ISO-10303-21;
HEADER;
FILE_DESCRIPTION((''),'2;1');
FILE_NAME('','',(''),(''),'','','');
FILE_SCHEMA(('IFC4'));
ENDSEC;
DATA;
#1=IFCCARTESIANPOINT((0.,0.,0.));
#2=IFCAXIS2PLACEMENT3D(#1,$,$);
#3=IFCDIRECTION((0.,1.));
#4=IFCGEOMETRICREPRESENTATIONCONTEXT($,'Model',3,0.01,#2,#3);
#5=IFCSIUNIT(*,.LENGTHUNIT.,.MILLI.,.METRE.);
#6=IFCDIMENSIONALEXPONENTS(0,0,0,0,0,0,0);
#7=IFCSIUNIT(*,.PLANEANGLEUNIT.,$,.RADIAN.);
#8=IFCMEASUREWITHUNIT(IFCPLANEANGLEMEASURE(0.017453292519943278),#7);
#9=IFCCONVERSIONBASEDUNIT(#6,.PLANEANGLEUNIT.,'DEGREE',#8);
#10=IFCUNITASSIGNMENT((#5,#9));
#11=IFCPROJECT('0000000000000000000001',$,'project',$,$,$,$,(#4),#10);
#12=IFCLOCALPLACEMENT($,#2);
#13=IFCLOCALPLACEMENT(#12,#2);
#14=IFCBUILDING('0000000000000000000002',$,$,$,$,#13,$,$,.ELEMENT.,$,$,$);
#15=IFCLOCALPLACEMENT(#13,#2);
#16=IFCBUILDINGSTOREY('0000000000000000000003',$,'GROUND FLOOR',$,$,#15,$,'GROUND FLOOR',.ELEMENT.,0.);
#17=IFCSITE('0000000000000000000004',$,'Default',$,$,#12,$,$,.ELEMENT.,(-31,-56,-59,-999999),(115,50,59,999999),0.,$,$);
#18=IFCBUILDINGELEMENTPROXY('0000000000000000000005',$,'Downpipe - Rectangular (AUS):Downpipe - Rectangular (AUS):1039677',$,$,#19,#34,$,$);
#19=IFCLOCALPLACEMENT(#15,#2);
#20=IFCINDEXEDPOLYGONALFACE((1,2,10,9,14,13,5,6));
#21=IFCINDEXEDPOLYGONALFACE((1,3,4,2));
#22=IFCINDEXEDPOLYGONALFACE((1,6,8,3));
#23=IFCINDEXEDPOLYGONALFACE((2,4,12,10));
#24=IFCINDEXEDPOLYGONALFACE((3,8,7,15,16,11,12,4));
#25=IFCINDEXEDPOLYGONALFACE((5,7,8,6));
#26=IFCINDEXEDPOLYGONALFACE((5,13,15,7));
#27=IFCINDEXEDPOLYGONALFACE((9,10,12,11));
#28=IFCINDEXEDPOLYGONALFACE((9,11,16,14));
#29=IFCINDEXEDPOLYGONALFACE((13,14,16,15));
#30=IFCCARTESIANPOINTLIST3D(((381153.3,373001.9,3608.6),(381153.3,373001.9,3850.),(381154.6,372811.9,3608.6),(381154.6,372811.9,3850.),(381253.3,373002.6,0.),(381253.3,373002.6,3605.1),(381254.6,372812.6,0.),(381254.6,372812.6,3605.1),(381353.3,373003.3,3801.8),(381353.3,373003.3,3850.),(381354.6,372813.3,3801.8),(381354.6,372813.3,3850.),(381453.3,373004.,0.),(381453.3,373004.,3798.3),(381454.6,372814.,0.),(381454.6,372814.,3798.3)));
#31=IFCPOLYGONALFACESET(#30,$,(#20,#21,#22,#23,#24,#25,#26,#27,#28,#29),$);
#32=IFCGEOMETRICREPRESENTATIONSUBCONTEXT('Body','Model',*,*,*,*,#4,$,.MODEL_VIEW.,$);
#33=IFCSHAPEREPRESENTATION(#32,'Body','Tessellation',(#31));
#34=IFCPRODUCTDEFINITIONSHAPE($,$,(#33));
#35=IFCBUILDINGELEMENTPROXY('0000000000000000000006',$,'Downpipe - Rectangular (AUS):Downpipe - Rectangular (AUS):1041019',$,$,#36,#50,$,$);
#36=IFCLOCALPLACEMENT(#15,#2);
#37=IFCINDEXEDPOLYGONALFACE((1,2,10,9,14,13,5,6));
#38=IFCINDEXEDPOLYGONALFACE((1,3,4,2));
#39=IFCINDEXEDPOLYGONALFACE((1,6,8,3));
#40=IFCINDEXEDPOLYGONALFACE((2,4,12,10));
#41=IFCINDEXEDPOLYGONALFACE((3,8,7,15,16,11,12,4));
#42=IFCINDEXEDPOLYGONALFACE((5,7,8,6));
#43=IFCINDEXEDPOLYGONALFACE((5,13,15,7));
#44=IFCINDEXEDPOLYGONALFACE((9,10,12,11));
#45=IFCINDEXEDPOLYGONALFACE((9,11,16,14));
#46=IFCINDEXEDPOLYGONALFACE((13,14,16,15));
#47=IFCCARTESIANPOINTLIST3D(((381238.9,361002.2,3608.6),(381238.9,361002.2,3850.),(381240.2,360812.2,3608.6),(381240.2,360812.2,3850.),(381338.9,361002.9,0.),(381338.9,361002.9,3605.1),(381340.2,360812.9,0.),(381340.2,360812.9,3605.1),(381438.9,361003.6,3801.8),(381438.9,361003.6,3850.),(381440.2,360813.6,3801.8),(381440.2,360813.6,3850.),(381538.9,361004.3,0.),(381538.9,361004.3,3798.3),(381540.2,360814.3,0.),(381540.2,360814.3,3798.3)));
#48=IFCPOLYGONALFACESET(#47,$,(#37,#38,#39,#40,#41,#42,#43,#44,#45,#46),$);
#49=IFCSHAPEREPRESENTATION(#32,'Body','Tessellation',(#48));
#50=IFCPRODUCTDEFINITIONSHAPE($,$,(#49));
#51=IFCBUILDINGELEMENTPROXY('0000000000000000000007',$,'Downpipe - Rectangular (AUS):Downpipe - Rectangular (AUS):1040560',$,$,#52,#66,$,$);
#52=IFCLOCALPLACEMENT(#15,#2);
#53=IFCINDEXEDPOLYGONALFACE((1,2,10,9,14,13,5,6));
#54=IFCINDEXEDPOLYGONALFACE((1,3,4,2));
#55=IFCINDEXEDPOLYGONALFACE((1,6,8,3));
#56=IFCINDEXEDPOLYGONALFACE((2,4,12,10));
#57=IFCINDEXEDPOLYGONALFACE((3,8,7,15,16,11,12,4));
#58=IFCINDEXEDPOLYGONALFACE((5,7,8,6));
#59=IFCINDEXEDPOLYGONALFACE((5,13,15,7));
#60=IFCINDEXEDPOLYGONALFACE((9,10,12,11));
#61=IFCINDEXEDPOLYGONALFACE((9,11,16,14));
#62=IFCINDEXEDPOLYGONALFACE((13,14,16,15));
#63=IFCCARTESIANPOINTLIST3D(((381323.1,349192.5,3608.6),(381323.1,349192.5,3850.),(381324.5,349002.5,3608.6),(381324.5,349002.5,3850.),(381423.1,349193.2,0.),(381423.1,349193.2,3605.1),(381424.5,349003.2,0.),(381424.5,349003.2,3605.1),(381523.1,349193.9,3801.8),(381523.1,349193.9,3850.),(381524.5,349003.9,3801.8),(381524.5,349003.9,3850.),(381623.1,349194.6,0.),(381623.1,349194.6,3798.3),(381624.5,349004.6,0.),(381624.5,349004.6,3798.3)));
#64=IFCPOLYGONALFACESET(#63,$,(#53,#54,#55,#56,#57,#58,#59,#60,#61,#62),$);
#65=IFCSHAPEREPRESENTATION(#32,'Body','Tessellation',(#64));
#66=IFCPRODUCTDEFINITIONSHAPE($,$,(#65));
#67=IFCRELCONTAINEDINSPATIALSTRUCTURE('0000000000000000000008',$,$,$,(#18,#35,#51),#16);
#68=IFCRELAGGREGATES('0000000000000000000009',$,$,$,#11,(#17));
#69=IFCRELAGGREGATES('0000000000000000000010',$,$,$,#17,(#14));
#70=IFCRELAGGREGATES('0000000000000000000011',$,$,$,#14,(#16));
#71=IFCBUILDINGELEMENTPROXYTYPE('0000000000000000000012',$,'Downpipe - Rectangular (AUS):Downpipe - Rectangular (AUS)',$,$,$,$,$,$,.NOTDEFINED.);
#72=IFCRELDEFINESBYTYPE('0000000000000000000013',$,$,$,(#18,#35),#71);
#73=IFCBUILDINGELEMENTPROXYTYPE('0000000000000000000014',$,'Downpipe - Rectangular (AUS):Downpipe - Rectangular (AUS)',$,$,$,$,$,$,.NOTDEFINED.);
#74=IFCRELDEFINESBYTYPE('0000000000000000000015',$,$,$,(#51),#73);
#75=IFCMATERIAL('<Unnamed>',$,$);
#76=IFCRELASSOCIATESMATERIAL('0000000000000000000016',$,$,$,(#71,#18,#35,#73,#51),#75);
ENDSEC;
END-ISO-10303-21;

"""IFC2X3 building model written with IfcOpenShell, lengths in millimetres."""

from ifc_helpers import new_model, entity, si_unit, converted_unit, direction, frame, origin, place, context, subcontext, project, spatial, polyline, outline, extrude, source, transform, mapped, material, type_object, type_shapes, element, save


model = new_model("IFC2X3")

# Units and contexts
model_context = context("Model", 3, precision=0.01, world=origin(), true_north=direction((0.0, 1.0)))
body_context = subcontext(model_context, "Body", "Model", "MODEL_VIEW")
ifc_project = project(units=[si_unit("LENGTHUNIT", "METRE", prefix="MILLI"), converted_unit("PLANEANGLEUNIT", "DEGREE", entity("IfcPlaneAngleMeasure", 0.017453292519943278), si_unit("PLANEANGLEUNIT", "RADIAN"), dimensions=[0, 0, 0, 0, 0, 0, 0])], contexts=[model_context])

# Site, building, storey
site_placement = place(None, origin())
site = spatial("IfcSite", under=ifc_project, at=site_placement, Name="Default", CompositionType="ELEMENT", RefLatitude=(-31, -56, -59, -999999), RefLongitude=(115, 50, 59, 999999), RefElevation=0.0)
building_placement = place(site_placement, origin())
building = spatial("IfcBuilding", under=site, at=building_placement, CompositionType="ELEMENT")
storey_placement = place(building_placement, origin())
storey = spatial("IfcBuildingStorey", under=building, at=storey_placement, Name="GROUND FLOOR", LongName="GROUND FLOOR", CompositionType="ELEMENT", Elevation=0.0)

# Building element proxies
ifc_material_1 = material(Name="<Unnamed>")
building_element_proxy_type_1 = type_object("IfcBuildingElementProxyType", Name="Downpipe - Rectangular (AUS):Downpipe - Rectangular (AUS)", PredefinedType="NOTDEFINED", material=ifc_material_1)
shared_shape_1 = source(origin(), body_context, "Body", "SweptSolid", [
    extrude(outline(polyline([(-2814.2, -150.0), (984.1, -150.0), (987.5, -50.0), (1035.8, -50.0), (1035.8, 150.0), (794.4, 150.0), (790.9, 50.0), (-2814.2, 50.0), (-2814.2, -150.0)])), frame((100.0, -95.0, 2814.2), z_axis=(0.0, 1.0, 0.0), x_axis=(0.0, 0.0, 1.0)), (0.0, 0.0, 1.0), 190.0),
])
type_shapes(building_element_proxy_type_1, [shared_shape_1])
for number, where, z_axis, x_axis, name in (
    (1, (381403.9, 372908.7, 0.0), (0.0, 0.0, 1.0), (-0.999975, -0.007134, 0.0), "Downpipe - Rectangular (AUS):Downpipe - Rectangular (AUS):1039677"),
    (2, (381489.5, 360909.0, 0.0), (0.0, 0.0, 1.0), (-0.999975, -0.007134, 0.0), "Downpipe - Rectangular (AUS):Downpipe - Rectangular (AUS):1041019"),
):
    element("IfcBuildingElementProxy", number, at=place(storey_placement, frame(where, z_axis=z_axis, x_axis=x_axis)), inside=storey, type_object=building_element_proxy_type_1, material=ifc_material_1, Name=name, context=body_context, shape_type="MappedRepresentation", body=[
        mapped(shared_shape_1, transform((0.0, 0.0, 0.0), scale=1.0)),
    ])
building_element_proxy_type_2 = type_object("IfcBuildingElementProxyType", Name="Downpipe - Rectangular (AUS):Downpipe - Rectangular (AUS)", PredefinedType="NOTDEFINED", material=ifc_material_1)
shared_shape_2 = source(origin(), body_context, "Body", "SweptSolid", [
    extrude(outline(polyline([(-50.0, -2814.2), (150.0, -2814.2), (150.0, 984.1), (50.0, 987.5), (50.0, 1035.8), (-150.0, 1035.8), (-150.0, 794.4), (-50.0, 790.9), (-50.0, -2814.2)])), frame((100.0, -95.0, 2814.2), z_axis=(0.0, 1.0, 0.0), x_axis=(-1.0, 0.0, 0.0)), (0.0, 0.0, 1.0), 190.0),
])
type_shapes(building_element_proxy_type_2, [shared_shape_2])
proxy_1_placement = place(storey_placement, frame((381573.8, 349099.3, 0.0), z_axis=(0.0, 0.0, 1.0), x_axis=(-0.999975, -0.007134, 0.0)))
element("IfcBuildingElementProxy", 3, at=proxy_1_placement, inside=storey, type_object=building_element_proxy_type_2, material=ifc_material_1, Name="Downpipe - Rectangular (AUS):Downpipe - Rectangular (AUS):1040560", context=body_context, shape_type="MappedRepresentation", body=[
    mapped(shared_shape_2, transform((0.0, 0.0, 0.0), scale=1.0)),
])

save(model, "model.ifc")
